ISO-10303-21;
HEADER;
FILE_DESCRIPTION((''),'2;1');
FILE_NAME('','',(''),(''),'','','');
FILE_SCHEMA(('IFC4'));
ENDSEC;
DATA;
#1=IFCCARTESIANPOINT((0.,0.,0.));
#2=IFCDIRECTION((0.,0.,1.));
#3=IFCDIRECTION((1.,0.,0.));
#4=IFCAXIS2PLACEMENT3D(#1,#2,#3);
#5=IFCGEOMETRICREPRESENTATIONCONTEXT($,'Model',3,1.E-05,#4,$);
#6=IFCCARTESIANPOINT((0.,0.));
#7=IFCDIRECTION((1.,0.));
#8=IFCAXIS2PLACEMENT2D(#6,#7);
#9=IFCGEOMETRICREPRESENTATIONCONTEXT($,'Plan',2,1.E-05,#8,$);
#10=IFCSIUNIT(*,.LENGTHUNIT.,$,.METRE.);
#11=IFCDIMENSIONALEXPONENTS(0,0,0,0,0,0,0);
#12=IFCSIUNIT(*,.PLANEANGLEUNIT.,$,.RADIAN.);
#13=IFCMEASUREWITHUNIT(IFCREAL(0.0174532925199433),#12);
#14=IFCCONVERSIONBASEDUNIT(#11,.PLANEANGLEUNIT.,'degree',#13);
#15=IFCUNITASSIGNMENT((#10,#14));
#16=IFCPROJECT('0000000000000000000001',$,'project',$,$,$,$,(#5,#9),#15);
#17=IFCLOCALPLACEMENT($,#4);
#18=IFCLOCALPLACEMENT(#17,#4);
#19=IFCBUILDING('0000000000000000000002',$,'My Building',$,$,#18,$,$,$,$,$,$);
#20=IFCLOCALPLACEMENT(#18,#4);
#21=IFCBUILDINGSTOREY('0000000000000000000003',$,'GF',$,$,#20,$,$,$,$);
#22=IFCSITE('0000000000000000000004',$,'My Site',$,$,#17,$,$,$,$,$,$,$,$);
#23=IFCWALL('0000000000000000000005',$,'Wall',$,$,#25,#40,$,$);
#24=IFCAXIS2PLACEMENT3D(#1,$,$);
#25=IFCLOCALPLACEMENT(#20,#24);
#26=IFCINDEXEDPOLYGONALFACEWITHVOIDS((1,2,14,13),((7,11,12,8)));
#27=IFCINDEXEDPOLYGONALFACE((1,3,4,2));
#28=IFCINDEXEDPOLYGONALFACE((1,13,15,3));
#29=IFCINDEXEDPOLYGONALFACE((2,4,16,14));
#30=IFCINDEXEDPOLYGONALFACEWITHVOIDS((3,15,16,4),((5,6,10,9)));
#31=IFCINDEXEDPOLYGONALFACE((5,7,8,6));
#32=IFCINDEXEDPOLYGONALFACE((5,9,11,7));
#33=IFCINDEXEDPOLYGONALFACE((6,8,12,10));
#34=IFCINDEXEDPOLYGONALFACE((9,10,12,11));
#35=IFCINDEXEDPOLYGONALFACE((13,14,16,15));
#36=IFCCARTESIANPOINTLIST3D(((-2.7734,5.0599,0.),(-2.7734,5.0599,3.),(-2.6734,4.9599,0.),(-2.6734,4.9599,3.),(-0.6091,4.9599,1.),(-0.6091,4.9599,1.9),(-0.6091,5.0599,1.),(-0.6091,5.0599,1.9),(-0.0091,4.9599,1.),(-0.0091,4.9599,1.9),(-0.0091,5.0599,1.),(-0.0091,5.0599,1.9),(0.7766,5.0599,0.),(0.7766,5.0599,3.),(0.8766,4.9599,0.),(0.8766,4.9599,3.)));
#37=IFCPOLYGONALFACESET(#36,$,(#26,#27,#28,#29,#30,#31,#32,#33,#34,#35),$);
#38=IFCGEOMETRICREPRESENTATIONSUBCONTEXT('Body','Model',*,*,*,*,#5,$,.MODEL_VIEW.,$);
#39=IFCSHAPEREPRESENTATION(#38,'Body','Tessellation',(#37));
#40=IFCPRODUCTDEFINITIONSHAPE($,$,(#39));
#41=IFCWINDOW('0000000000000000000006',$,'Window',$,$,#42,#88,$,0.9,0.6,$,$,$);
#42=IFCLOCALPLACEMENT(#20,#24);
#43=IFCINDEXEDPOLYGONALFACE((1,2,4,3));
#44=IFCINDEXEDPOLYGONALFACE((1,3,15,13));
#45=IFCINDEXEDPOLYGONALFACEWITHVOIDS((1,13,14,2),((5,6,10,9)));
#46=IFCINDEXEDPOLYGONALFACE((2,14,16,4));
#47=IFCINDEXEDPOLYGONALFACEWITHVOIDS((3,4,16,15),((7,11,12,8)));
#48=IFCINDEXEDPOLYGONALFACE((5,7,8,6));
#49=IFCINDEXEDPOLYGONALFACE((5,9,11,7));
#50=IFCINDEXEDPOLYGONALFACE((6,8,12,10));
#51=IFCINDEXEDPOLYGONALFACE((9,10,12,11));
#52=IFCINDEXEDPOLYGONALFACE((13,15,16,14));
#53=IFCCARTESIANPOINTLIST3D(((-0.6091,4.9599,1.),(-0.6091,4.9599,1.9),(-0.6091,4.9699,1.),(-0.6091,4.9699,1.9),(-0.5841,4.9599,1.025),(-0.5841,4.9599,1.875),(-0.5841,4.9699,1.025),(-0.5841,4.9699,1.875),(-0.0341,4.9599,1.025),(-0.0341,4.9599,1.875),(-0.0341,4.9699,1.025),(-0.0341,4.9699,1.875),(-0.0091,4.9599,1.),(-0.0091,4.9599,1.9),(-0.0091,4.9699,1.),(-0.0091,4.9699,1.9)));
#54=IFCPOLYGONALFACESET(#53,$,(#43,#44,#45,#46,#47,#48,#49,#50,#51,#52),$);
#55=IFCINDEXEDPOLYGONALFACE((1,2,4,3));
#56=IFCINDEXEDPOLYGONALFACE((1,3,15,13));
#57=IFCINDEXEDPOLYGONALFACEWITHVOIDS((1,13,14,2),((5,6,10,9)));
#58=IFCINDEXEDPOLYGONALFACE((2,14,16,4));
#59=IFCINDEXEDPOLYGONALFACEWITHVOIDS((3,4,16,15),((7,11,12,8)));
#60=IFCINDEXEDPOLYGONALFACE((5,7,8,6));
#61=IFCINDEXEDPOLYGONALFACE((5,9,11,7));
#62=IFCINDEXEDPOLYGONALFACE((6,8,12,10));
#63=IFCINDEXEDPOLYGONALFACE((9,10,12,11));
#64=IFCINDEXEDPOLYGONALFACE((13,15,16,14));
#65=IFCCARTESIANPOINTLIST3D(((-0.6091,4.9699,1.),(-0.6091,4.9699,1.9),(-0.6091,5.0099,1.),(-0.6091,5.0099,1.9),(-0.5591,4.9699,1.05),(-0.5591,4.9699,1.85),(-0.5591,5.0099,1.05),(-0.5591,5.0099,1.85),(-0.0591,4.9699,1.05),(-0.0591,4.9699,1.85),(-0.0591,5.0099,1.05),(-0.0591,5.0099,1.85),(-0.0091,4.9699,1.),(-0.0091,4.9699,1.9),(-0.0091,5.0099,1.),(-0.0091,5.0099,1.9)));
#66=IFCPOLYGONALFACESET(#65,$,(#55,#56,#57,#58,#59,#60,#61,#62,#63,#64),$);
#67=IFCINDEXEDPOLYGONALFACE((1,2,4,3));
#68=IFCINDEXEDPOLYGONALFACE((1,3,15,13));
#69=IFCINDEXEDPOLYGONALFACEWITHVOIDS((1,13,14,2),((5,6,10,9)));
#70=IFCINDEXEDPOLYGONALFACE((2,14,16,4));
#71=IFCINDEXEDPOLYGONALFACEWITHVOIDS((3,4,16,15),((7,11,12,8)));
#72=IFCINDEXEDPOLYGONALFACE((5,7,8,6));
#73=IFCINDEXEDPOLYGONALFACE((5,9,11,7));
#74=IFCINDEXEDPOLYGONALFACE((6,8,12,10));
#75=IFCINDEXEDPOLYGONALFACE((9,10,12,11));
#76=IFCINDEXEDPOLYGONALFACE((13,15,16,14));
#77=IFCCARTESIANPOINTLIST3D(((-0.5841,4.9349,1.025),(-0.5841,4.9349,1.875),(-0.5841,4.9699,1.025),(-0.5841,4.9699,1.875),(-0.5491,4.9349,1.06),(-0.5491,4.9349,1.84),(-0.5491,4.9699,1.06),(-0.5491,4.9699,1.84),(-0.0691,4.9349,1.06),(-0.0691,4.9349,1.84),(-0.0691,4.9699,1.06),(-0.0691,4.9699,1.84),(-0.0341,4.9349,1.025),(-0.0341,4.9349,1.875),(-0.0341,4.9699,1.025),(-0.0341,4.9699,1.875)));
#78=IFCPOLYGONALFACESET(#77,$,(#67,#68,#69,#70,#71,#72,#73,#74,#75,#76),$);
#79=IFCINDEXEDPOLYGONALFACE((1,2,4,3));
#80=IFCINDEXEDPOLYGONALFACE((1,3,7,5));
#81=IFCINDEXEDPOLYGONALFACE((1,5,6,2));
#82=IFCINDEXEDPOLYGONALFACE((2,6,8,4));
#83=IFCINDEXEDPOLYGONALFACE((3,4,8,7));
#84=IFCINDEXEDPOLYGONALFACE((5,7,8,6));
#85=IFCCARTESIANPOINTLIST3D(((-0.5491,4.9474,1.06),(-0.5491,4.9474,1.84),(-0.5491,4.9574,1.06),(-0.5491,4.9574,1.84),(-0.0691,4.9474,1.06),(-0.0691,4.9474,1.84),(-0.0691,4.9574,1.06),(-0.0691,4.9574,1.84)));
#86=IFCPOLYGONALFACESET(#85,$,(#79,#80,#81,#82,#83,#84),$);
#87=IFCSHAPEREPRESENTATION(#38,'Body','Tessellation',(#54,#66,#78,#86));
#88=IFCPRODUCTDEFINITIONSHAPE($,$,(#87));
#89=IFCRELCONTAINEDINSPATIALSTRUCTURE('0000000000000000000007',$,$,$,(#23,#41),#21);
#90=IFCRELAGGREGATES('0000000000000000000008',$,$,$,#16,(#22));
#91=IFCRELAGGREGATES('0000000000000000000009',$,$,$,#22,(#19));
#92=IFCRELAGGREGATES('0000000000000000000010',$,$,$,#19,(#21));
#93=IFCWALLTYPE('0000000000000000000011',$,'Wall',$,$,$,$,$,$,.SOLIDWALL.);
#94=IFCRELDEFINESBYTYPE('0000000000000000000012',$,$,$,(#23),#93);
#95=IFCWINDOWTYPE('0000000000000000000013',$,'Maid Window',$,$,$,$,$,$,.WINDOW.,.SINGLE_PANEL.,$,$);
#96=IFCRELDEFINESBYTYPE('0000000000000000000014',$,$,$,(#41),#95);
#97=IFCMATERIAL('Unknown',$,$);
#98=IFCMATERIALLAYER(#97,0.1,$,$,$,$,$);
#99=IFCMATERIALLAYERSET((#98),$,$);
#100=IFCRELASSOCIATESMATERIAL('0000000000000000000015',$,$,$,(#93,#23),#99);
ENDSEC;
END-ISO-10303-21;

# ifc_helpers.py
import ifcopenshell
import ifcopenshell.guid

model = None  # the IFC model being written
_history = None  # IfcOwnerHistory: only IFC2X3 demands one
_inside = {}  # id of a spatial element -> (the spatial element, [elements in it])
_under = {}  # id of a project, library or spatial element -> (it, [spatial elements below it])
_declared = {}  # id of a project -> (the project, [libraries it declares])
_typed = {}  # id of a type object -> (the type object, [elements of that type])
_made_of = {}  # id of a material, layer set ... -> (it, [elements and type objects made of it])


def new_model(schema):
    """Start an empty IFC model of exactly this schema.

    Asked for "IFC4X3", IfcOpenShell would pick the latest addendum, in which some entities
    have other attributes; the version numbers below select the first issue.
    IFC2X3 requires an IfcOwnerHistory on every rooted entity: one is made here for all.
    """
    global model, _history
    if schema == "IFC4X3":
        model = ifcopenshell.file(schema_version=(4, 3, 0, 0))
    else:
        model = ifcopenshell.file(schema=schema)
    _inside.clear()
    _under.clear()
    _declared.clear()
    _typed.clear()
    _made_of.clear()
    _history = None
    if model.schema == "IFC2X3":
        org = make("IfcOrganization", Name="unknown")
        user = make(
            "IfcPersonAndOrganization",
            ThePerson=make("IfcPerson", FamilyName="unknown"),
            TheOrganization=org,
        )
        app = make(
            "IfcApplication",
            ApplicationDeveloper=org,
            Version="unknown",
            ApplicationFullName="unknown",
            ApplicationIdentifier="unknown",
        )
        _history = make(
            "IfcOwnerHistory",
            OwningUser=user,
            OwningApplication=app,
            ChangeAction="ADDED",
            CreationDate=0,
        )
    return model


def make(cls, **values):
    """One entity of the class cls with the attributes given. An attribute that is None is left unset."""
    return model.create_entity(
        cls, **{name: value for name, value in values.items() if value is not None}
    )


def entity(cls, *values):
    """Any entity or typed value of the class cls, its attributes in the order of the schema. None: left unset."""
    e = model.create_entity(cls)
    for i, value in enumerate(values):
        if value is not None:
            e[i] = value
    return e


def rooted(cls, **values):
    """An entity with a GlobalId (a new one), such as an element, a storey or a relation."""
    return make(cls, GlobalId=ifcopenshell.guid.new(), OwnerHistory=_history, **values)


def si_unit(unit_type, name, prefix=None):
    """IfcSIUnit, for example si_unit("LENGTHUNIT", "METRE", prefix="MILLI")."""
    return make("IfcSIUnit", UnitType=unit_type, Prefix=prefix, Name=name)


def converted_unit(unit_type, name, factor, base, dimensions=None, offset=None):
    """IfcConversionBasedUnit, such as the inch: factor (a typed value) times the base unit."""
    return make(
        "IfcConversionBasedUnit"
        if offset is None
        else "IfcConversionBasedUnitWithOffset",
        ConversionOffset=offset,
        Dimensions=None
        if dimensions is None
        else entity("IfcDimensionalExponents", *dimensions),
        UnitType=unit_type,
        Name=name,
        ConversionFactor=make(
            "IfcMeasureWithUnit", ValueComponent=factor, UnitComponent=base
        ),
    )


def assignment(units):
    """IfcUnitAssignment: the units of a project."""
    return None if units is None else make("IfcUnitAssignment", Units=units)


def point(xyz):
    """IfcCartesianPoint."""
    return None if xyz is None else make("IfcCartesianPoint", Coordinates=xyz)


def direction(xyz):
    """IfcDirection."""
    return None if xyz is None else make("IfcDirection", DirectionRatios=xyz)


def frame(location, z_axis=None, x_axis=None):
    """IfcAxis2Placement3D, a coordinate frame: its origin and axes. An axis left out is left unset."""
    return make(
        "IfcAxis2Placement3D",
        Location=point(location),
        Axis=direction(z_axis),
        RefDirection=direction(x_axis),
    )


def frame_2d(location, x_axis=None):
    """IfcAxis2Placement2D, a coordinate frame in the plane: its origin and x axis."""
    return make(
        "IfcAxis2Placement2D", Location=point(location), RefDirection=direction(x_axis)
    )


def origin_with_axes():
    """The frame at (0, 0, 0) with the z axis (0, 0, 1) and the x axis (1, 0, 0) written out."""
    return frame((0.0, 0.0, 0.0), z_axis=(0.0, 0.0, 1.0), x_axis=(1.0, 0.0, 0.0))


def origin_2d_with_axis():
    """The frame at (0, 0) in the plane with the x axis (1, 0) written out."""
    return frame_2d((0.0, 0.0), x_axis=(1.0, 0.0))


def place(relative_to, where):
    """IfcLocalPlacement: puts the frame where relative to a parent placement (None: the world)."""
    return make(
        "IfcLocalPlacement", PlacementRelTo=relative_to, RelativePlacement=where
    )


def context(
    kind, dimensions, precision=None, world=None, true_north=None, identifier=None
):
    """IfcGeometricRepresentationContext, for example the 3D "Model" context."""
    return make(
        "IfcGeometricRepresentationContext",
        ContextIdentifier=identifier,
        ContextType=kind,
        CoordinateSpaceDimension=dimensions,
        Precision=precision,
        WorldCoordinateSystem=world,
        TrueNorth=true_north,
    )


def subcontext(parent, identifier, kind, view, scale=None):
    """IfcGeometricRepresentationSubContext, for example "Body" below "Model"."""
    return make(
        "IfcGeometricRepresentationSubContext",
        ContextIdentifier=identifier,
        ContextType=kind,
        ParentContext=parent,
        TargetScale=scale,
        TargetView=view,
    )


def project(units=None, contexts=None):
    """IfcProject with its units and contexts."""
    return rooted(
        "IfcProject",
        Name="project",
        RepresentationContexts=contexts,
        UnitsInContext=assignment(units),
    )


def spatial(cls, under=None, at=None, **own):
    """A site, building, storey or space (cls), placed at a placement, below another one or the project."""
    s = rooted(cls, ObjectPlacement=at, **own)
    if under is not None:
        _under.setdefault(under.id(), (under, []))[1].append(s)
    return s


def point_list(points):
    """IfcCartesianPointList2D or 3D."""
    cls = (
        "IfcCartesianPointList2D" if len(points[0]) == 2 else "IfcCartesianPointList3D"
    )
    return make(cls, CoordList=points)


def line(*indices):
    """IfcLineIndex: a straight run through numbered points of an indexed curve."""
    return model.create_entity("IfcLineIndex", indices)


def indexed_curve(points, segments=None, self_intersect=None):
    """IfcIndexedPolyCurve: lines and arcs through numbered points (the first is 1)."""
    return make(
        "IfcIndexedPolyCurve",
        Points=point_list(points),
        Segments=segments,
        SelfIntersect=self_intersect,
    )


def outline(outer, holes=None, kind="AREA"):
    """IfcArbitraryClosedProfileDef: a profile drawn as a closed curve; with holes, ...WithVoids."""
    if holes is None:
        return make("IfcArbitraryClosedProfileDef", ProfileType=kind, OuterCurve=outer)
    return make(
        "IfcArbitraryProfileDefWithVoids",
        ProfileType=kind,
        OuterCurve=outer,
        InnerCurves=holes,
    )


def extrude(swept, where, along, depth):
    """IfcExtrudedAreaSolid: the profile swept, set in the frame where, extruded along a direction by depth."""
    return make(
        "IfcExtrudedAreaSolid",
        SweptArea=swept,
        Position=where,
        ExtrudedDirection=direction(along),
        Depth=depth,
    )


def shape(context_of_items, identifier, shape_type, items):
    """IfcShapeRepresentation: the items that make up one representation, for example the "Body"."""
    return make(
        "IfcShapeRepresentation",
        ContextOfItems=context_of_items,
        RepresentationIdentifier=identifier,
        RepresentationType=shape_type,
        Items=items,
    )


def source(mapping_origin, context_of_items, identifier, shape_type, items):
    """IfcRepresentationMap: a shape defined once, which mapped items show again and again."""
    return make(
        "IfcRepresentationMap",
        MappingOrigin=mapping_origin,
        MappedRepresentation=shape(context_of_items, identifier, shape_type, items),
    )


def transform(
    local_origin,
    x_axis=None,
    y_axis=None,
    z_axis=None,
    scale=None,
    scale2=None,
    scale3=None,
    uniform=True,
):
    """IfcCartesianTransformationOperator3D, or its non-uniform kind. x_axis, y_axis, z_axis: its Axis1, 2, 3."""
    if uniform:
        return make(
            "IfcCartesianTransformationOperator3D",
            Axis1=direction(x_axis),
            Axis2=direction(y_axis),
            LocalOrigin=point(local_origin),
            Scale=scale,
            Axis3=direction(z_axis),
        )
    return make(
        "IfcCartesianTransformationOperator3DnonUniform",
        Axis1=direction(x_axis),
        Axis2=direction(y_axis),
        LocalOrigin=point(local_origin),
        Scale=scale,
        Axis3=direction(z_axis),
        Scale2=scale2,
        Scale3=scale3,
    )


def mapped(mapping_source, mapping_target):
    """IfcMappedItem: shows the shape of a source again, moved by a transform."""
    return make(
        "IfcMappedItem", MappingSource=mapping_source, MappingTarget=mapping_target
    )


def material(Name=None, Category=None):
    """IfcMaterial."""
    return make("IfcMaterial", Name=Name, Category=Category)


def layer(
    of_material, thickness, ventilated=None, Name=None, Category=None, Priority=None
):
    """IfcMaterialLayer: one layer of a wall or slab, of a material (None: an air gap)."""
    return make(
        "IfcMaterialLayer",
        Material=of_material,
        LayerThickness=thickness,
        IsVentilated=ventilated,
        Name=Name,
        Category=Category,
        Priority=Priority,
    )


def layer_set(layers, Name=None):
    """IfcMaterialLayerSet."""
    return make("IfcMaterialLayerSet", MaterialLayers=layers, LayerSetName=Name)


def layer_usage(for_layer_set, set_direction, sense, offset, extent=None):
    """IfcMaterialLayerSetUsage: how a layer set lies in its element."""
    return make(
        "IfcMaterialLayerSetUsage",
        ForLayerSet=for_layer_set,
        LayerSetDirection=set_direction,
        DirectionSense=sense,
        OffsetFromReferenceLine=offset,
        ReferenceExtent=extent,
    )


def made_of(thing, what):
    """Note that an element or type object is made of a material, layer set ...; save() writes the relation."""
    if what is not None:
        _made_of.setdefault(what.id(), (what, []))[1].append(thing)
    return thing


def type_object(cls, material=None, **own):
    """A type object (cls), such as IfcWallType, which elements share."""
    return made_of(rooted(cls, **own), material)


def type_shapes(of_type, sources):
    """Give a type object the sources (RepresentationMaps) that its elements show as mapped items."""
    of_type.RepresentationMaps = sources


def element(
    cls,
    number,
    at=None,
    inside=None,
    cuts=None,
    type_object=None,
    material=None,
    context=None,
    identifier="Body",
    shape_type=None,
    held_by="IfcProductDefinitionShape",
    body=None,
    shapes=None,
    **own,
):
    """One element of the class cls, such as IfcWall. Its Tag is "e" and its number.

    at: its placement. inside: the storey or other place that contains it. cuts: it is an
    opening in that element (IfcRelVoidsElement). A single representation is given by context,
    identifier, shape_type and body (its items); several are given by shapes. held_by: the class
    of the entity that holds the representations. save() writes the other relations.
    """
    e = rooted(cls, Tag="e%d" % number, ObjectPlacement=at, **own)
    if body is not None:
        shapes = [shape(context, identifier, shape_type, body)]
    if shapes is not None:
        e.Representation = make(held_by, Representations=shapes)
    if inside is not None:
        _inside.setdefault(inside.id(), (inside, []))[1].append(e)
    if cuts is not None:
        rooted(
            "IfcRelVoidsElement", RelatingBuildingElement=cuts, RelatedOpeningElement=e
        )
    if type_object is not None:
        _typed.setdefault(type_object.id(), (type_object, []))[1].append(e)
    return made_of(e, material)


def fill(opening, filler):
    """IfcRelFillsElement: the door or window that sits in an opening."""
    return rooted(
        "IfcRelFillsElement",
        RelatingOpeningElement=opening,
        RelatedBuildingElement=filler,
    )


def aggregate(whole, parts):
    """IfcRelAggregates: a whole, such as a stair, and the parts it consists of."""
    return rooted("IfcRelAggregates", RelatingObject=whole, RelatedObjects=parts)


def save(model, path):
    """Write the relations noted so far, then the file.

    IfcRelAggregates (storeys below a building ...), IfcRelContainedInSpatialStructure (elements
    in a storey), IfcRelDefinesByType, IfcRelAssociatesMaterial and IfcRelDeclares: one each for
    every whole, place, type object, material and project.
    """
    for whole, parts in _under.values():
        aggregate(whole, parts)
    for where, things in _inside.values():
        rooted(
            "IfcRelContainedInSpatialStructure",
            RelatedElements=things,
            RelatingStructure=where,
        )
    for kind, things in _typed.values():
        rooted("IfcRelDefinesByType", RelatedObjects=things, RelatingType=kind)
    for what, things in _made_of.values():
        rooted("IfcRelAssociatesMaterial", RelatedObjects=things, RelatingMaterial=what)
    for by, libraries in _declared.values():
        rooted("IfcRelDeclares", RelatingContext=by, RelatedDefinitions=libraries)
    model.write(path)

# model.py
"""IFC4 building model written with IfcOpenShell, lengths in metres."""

from ifc_helpers import new_model, entity, si_unit, converted_unit, frame, origin_with_axes, origin_2d_with_axis, place, context, subcontext, project, spatial, line, indexed_curve, outline, extrude, shape, source, transform, mapped, material, layer, layer_set, layer_usage, type_object, type_shapes, element, fill, save


model = new_model("IFC4")

# Units and contexts
model_context = context("Model", 3, precision=1e-05, world=origin_with_axes())
plan_context = context("Plan", 2, precision=1e-05, world=origin_2d_with_axis())
body_context_1 = subcontext(model_context, "Body", "Model", "MODEL_VIEW")
body_context_2 = subcontext(plan_context, "Body", "Plan", "PLAN_VIEW")
ifc_project = project(units=[si_unit("LENGTHUNIT", "METRE"), converted_unit("PLANEANGLEUNIT", "degree", entity("IfcReal", 0.0174532925199433), si_unit("PLANEANGLEUNIT", "RADIAN"), dimensions=[0, 0, 0, 0, 0, 0, 0])], contexts=[model_context, plan_context])

# Site, building, storey
site_placement = place(None, origin_with_axes())
site = spatial("IfcSite", under=ifc_project, at=site_placement, Name="My Site")
building_placement = place(site_placement, origin_with_axes())
building = spatial("IfcBuilding", under=site, at=building_placement, Name="My Building")
storey_placement = place(building_placement, origin_with_axes())
storey = spatial("IfcBuildingStorey", under=building, at=storey_placement, Name="GF")

# Shared definitions
ifc_material_1 = material(Name="Unknown")

# Shared definitions
ifc_layer_1 = layer(ifc_material_1, 0.1)
ifc_layer_set_1 = layer_set([ifc_layer_1])
wall_type = type_object("IfcWallType", Name="Wall", PredefinedType="SOLIDWALL", material=ifc_layer_set_1)

# Wall, opening, window
ifc_layer_usage_1 = layer_usage(ifc_layer_set_1, "AXIS2", "POSITIVE", 0.0)
wall_1_placement = place(storey_placement, frame((0.7766, 5.0599, 0.0), z_axis=(0.0, 0.0, 1.0), x_axis=(-1.0, 0.0, 0.0)))
wall_1 = element("IfcWall", 1, at=wall_1_placement, inside=storey, type_object=wall_type, material=ifc_layer_usage_1, Name="Wall", context=body_context_1, shape_type="SweptSolid", body=[
    extrude(outline(indexed_curve([(0.0, 0.0), (-0.1, 0.1), (3.45, 0.1), (3.55, 0.0)], segments=[line(1, 2, 3, 4, 1)])), origin_with_axes(), (0.0, 0.0, 1.0), 3.0),
])
shared_shape_1 = source(origin_with_axes(), body_context_1, "Body", "SweptSolid", [
    extrude(outline(indexed_curve([(0.0, 0.0), (0.6, 0.0), (0.6, 0.9), (0.0, 0.9)], segments=[line(1, 2, 3, 4, 1)])), frame((0.0, -0.6, 0.0), z_axis=(0.0, -1.0, 0.0), x_axis=(1.0, 0.0, 0.0)), (0.0, 0.0, -1.0), 1.2),
])
opening_1_placement = place(wall_1_placement, frame((0.7857, 0.0, 1.0), z_axis=(0.0, 0.0, 1.0), x_axis=(1.0, 0.0, 0.0)))
opening_1 = element("IfcOpeningElement", 2, at=opening_1_placement, cuts=wall_1, PredefinedType="OPENING", context=body_context_1, shape_type="MappedRepresentation", body=[
    mapped(shared_shape_1, transform((0.0, 0.0, 0.0), x_axis=(1.0, 0.0, 0.0), y_axis=(0.0, 1.0, 0.0), z_axis=(0.0, 0.0, 1.0), scale=1.0)),
])
window_type_1 = type_object("IfcWindowType", Name="Maid Window", PartitioningType="SINGLE_PANEL", PredefinedType="WINDOW")
shared_shape_2 = source(origin_with_axes(), body_context_1, "Body", "SweptSolid", [
    extrude(outline(indexed_curve([(0.0, 0.0), (0.6, 0.0), (0.6, 0.9), (0.0, 0.9)], segments=[line(1, 2, 3, 4, 1)]), holes=[indexed_curve([(0.025, 0.025), (0.575, 0.025), (0.575, 0.875), (0.025, 0.875)], segments=[line(1, 2, 3, 4, 1)])]), frame((0.0, 0.09, 0.0), z_axis=(0.0, -1.0, 0.0), x_axis=(1.0, 0.0, 0.0)), (0.0, 0.0, -1.0), 0.01),
    extrude(outline(indexed_curve([(0.0, 0.0), (0.6, 0.0), (0.6, 0.9), (0.0, 0.9)], segments=[line(1, 2, 3, 4, 1)]), holes=[indexed_curve([(0.05, 0.05), (0.55, 0.05), (0.55, 0.85), (0.05, 0.85)], segments=[line(1, 2, 3, 4, 1)])]), frame((0.0, 0.05, 0.0), z_axis=(0.0, -1.0, 0.0), x_axis=(1.0, 0.0, 0.0)), (0.0, 0.0, -1.0), 0.04),
    extrude(outline(indexed_curve([(0.0, 0.0), (0.55, 0.0), (0.55, 0.85), (0.0, 0.85)], segments=[line(1, 2, 3, 4, 1)]), holes=[indexed_curve([(0.035, 0.035), (0.515, 0.035), (0.515, 0.815), (0.035, 0.815)], segments=[line(1, 2, 3, 4, 1)])]), frame((0.025, 0.09, 0.025), z_axis=(0.0, -1.0, 0.0), x_axis=(1.0, 0.0, 0.0)), (0.0, 0.0, -1.0), 0.035),
    extrude(outline(indexed_curve([(0.035, 0.035), (0.515, 0.035), (0.515, 0.815), (0.035, 0.815)], segments=[line(1, 2, 3, 4, 1)])), frame((0.025, 0.1025, 0.025), z_axis=(0.0, -1.0, 0.0), x_axis=(1.0, 0.0, 0.0)), (0.0, 0.0, -1.0), 0.01),
])
shared_shape_3 = source(origin_with_axes(), body_context_2, "Body", "Curve2D", [
    entity("IfcIndexedPolyCurve", entity("IfcCartesianPointList2D", [[0.05, 0.05], [0.55, 0.05]])),
    entity("IfcIndexedPolyCurve", entity("IfcCartesianPointList2D", [[0.0, 0.1], [0.025, 0.1], [0.025, 0.09], [0.05, 0.09], [0.05, 0.05], [0.0, 0.05]]), [entity("IfcLineIndex", [1, 2, 3, 4, 5, 6, 1])]),
    entity("IfcIndexedPolyCurve", entity("IfcCartesianPointList2D", [[0.6, 0.1], [0.575, 0.1], [0.575, 0.09], [0.55, 0.09], [0.55, 0.05], [0.6, 0.05]]), [entity("IfcLineIndex", [1, 2, 3, 4, 5, 6, 1])]),
    entity("IfcIndexedPolyCurve", entity("IfcCartesianPointList2D", [[0.025, 0.09], [0.06, 0.09], [0.06, 0.125], [0.025, 0.125]]), [entity("IfcLineIndex", [1, 2, 3, 4, 1])]),
    entity("IfcIndexedPolyCurve", entity("IfcCartesianPointList2D", [[0.575, 0.09], [0.54, 0.09], [0.54, 0.125], [0.575, 0.125]]), [entity("IfcLineIndex", [1, 2, 3, 4, 1])]),
    entity("IfcIndexedPolyCurve", entity("IfcCartesianPointList2D", [[0.06, 0.09], [0.54, 0.09]])),
    entity("IfcIndexedPolyCurve", entity("IfcCartesianPointList2D", [[0.06, 0.125], [0.54, 0.125]])),
    entity("IfcIndexedPolyCurve", entity("IfcCartesianPointList2D", [[0.06, 0.1075], [0.54, 0.1075]])),
])
type_shapes(window_type_1, [shared_shape_2, shared_shape_3])
window_1_placement = place(opening_1_placement, frame((0.0, 0.0, 0.0), z_axis=(0.0, 0.0, 1.0), x_axis=(1.0, 0.0, 0.0)))
window_1 = element("IfcWindow", 3, at=window_1_placement, inside=storey, type_object=window_type_1, Name="Window", OverallHeight=0.9, OverallWidth=0.6, shapes=[
    shape(body_context_1, "Body", "MappedRepresentation", [mapped(shared_shape_2, transform((0.0, 0.0, 0.0), x_axis=(1.0, 0.0, 0.0), y_axis=(0.0, 1.0, 0.0), z_axis=(0.0, 0.0, 1.0), scale=1.0))]),
    shape(body_context_2, "Body", "MappedRepresentation", [mapped(shared_shape_3, transform((0.0, 0.0, 0.0), x_axis=(1.0, 0.0, 0.0), y_axis=(0.0, 1.0, 0.0), z_axis=(0.0, 0.0, 1.0), scale=1.0))]),
])
fill(opening_1, window_1)

save(model, "model.ifc")
